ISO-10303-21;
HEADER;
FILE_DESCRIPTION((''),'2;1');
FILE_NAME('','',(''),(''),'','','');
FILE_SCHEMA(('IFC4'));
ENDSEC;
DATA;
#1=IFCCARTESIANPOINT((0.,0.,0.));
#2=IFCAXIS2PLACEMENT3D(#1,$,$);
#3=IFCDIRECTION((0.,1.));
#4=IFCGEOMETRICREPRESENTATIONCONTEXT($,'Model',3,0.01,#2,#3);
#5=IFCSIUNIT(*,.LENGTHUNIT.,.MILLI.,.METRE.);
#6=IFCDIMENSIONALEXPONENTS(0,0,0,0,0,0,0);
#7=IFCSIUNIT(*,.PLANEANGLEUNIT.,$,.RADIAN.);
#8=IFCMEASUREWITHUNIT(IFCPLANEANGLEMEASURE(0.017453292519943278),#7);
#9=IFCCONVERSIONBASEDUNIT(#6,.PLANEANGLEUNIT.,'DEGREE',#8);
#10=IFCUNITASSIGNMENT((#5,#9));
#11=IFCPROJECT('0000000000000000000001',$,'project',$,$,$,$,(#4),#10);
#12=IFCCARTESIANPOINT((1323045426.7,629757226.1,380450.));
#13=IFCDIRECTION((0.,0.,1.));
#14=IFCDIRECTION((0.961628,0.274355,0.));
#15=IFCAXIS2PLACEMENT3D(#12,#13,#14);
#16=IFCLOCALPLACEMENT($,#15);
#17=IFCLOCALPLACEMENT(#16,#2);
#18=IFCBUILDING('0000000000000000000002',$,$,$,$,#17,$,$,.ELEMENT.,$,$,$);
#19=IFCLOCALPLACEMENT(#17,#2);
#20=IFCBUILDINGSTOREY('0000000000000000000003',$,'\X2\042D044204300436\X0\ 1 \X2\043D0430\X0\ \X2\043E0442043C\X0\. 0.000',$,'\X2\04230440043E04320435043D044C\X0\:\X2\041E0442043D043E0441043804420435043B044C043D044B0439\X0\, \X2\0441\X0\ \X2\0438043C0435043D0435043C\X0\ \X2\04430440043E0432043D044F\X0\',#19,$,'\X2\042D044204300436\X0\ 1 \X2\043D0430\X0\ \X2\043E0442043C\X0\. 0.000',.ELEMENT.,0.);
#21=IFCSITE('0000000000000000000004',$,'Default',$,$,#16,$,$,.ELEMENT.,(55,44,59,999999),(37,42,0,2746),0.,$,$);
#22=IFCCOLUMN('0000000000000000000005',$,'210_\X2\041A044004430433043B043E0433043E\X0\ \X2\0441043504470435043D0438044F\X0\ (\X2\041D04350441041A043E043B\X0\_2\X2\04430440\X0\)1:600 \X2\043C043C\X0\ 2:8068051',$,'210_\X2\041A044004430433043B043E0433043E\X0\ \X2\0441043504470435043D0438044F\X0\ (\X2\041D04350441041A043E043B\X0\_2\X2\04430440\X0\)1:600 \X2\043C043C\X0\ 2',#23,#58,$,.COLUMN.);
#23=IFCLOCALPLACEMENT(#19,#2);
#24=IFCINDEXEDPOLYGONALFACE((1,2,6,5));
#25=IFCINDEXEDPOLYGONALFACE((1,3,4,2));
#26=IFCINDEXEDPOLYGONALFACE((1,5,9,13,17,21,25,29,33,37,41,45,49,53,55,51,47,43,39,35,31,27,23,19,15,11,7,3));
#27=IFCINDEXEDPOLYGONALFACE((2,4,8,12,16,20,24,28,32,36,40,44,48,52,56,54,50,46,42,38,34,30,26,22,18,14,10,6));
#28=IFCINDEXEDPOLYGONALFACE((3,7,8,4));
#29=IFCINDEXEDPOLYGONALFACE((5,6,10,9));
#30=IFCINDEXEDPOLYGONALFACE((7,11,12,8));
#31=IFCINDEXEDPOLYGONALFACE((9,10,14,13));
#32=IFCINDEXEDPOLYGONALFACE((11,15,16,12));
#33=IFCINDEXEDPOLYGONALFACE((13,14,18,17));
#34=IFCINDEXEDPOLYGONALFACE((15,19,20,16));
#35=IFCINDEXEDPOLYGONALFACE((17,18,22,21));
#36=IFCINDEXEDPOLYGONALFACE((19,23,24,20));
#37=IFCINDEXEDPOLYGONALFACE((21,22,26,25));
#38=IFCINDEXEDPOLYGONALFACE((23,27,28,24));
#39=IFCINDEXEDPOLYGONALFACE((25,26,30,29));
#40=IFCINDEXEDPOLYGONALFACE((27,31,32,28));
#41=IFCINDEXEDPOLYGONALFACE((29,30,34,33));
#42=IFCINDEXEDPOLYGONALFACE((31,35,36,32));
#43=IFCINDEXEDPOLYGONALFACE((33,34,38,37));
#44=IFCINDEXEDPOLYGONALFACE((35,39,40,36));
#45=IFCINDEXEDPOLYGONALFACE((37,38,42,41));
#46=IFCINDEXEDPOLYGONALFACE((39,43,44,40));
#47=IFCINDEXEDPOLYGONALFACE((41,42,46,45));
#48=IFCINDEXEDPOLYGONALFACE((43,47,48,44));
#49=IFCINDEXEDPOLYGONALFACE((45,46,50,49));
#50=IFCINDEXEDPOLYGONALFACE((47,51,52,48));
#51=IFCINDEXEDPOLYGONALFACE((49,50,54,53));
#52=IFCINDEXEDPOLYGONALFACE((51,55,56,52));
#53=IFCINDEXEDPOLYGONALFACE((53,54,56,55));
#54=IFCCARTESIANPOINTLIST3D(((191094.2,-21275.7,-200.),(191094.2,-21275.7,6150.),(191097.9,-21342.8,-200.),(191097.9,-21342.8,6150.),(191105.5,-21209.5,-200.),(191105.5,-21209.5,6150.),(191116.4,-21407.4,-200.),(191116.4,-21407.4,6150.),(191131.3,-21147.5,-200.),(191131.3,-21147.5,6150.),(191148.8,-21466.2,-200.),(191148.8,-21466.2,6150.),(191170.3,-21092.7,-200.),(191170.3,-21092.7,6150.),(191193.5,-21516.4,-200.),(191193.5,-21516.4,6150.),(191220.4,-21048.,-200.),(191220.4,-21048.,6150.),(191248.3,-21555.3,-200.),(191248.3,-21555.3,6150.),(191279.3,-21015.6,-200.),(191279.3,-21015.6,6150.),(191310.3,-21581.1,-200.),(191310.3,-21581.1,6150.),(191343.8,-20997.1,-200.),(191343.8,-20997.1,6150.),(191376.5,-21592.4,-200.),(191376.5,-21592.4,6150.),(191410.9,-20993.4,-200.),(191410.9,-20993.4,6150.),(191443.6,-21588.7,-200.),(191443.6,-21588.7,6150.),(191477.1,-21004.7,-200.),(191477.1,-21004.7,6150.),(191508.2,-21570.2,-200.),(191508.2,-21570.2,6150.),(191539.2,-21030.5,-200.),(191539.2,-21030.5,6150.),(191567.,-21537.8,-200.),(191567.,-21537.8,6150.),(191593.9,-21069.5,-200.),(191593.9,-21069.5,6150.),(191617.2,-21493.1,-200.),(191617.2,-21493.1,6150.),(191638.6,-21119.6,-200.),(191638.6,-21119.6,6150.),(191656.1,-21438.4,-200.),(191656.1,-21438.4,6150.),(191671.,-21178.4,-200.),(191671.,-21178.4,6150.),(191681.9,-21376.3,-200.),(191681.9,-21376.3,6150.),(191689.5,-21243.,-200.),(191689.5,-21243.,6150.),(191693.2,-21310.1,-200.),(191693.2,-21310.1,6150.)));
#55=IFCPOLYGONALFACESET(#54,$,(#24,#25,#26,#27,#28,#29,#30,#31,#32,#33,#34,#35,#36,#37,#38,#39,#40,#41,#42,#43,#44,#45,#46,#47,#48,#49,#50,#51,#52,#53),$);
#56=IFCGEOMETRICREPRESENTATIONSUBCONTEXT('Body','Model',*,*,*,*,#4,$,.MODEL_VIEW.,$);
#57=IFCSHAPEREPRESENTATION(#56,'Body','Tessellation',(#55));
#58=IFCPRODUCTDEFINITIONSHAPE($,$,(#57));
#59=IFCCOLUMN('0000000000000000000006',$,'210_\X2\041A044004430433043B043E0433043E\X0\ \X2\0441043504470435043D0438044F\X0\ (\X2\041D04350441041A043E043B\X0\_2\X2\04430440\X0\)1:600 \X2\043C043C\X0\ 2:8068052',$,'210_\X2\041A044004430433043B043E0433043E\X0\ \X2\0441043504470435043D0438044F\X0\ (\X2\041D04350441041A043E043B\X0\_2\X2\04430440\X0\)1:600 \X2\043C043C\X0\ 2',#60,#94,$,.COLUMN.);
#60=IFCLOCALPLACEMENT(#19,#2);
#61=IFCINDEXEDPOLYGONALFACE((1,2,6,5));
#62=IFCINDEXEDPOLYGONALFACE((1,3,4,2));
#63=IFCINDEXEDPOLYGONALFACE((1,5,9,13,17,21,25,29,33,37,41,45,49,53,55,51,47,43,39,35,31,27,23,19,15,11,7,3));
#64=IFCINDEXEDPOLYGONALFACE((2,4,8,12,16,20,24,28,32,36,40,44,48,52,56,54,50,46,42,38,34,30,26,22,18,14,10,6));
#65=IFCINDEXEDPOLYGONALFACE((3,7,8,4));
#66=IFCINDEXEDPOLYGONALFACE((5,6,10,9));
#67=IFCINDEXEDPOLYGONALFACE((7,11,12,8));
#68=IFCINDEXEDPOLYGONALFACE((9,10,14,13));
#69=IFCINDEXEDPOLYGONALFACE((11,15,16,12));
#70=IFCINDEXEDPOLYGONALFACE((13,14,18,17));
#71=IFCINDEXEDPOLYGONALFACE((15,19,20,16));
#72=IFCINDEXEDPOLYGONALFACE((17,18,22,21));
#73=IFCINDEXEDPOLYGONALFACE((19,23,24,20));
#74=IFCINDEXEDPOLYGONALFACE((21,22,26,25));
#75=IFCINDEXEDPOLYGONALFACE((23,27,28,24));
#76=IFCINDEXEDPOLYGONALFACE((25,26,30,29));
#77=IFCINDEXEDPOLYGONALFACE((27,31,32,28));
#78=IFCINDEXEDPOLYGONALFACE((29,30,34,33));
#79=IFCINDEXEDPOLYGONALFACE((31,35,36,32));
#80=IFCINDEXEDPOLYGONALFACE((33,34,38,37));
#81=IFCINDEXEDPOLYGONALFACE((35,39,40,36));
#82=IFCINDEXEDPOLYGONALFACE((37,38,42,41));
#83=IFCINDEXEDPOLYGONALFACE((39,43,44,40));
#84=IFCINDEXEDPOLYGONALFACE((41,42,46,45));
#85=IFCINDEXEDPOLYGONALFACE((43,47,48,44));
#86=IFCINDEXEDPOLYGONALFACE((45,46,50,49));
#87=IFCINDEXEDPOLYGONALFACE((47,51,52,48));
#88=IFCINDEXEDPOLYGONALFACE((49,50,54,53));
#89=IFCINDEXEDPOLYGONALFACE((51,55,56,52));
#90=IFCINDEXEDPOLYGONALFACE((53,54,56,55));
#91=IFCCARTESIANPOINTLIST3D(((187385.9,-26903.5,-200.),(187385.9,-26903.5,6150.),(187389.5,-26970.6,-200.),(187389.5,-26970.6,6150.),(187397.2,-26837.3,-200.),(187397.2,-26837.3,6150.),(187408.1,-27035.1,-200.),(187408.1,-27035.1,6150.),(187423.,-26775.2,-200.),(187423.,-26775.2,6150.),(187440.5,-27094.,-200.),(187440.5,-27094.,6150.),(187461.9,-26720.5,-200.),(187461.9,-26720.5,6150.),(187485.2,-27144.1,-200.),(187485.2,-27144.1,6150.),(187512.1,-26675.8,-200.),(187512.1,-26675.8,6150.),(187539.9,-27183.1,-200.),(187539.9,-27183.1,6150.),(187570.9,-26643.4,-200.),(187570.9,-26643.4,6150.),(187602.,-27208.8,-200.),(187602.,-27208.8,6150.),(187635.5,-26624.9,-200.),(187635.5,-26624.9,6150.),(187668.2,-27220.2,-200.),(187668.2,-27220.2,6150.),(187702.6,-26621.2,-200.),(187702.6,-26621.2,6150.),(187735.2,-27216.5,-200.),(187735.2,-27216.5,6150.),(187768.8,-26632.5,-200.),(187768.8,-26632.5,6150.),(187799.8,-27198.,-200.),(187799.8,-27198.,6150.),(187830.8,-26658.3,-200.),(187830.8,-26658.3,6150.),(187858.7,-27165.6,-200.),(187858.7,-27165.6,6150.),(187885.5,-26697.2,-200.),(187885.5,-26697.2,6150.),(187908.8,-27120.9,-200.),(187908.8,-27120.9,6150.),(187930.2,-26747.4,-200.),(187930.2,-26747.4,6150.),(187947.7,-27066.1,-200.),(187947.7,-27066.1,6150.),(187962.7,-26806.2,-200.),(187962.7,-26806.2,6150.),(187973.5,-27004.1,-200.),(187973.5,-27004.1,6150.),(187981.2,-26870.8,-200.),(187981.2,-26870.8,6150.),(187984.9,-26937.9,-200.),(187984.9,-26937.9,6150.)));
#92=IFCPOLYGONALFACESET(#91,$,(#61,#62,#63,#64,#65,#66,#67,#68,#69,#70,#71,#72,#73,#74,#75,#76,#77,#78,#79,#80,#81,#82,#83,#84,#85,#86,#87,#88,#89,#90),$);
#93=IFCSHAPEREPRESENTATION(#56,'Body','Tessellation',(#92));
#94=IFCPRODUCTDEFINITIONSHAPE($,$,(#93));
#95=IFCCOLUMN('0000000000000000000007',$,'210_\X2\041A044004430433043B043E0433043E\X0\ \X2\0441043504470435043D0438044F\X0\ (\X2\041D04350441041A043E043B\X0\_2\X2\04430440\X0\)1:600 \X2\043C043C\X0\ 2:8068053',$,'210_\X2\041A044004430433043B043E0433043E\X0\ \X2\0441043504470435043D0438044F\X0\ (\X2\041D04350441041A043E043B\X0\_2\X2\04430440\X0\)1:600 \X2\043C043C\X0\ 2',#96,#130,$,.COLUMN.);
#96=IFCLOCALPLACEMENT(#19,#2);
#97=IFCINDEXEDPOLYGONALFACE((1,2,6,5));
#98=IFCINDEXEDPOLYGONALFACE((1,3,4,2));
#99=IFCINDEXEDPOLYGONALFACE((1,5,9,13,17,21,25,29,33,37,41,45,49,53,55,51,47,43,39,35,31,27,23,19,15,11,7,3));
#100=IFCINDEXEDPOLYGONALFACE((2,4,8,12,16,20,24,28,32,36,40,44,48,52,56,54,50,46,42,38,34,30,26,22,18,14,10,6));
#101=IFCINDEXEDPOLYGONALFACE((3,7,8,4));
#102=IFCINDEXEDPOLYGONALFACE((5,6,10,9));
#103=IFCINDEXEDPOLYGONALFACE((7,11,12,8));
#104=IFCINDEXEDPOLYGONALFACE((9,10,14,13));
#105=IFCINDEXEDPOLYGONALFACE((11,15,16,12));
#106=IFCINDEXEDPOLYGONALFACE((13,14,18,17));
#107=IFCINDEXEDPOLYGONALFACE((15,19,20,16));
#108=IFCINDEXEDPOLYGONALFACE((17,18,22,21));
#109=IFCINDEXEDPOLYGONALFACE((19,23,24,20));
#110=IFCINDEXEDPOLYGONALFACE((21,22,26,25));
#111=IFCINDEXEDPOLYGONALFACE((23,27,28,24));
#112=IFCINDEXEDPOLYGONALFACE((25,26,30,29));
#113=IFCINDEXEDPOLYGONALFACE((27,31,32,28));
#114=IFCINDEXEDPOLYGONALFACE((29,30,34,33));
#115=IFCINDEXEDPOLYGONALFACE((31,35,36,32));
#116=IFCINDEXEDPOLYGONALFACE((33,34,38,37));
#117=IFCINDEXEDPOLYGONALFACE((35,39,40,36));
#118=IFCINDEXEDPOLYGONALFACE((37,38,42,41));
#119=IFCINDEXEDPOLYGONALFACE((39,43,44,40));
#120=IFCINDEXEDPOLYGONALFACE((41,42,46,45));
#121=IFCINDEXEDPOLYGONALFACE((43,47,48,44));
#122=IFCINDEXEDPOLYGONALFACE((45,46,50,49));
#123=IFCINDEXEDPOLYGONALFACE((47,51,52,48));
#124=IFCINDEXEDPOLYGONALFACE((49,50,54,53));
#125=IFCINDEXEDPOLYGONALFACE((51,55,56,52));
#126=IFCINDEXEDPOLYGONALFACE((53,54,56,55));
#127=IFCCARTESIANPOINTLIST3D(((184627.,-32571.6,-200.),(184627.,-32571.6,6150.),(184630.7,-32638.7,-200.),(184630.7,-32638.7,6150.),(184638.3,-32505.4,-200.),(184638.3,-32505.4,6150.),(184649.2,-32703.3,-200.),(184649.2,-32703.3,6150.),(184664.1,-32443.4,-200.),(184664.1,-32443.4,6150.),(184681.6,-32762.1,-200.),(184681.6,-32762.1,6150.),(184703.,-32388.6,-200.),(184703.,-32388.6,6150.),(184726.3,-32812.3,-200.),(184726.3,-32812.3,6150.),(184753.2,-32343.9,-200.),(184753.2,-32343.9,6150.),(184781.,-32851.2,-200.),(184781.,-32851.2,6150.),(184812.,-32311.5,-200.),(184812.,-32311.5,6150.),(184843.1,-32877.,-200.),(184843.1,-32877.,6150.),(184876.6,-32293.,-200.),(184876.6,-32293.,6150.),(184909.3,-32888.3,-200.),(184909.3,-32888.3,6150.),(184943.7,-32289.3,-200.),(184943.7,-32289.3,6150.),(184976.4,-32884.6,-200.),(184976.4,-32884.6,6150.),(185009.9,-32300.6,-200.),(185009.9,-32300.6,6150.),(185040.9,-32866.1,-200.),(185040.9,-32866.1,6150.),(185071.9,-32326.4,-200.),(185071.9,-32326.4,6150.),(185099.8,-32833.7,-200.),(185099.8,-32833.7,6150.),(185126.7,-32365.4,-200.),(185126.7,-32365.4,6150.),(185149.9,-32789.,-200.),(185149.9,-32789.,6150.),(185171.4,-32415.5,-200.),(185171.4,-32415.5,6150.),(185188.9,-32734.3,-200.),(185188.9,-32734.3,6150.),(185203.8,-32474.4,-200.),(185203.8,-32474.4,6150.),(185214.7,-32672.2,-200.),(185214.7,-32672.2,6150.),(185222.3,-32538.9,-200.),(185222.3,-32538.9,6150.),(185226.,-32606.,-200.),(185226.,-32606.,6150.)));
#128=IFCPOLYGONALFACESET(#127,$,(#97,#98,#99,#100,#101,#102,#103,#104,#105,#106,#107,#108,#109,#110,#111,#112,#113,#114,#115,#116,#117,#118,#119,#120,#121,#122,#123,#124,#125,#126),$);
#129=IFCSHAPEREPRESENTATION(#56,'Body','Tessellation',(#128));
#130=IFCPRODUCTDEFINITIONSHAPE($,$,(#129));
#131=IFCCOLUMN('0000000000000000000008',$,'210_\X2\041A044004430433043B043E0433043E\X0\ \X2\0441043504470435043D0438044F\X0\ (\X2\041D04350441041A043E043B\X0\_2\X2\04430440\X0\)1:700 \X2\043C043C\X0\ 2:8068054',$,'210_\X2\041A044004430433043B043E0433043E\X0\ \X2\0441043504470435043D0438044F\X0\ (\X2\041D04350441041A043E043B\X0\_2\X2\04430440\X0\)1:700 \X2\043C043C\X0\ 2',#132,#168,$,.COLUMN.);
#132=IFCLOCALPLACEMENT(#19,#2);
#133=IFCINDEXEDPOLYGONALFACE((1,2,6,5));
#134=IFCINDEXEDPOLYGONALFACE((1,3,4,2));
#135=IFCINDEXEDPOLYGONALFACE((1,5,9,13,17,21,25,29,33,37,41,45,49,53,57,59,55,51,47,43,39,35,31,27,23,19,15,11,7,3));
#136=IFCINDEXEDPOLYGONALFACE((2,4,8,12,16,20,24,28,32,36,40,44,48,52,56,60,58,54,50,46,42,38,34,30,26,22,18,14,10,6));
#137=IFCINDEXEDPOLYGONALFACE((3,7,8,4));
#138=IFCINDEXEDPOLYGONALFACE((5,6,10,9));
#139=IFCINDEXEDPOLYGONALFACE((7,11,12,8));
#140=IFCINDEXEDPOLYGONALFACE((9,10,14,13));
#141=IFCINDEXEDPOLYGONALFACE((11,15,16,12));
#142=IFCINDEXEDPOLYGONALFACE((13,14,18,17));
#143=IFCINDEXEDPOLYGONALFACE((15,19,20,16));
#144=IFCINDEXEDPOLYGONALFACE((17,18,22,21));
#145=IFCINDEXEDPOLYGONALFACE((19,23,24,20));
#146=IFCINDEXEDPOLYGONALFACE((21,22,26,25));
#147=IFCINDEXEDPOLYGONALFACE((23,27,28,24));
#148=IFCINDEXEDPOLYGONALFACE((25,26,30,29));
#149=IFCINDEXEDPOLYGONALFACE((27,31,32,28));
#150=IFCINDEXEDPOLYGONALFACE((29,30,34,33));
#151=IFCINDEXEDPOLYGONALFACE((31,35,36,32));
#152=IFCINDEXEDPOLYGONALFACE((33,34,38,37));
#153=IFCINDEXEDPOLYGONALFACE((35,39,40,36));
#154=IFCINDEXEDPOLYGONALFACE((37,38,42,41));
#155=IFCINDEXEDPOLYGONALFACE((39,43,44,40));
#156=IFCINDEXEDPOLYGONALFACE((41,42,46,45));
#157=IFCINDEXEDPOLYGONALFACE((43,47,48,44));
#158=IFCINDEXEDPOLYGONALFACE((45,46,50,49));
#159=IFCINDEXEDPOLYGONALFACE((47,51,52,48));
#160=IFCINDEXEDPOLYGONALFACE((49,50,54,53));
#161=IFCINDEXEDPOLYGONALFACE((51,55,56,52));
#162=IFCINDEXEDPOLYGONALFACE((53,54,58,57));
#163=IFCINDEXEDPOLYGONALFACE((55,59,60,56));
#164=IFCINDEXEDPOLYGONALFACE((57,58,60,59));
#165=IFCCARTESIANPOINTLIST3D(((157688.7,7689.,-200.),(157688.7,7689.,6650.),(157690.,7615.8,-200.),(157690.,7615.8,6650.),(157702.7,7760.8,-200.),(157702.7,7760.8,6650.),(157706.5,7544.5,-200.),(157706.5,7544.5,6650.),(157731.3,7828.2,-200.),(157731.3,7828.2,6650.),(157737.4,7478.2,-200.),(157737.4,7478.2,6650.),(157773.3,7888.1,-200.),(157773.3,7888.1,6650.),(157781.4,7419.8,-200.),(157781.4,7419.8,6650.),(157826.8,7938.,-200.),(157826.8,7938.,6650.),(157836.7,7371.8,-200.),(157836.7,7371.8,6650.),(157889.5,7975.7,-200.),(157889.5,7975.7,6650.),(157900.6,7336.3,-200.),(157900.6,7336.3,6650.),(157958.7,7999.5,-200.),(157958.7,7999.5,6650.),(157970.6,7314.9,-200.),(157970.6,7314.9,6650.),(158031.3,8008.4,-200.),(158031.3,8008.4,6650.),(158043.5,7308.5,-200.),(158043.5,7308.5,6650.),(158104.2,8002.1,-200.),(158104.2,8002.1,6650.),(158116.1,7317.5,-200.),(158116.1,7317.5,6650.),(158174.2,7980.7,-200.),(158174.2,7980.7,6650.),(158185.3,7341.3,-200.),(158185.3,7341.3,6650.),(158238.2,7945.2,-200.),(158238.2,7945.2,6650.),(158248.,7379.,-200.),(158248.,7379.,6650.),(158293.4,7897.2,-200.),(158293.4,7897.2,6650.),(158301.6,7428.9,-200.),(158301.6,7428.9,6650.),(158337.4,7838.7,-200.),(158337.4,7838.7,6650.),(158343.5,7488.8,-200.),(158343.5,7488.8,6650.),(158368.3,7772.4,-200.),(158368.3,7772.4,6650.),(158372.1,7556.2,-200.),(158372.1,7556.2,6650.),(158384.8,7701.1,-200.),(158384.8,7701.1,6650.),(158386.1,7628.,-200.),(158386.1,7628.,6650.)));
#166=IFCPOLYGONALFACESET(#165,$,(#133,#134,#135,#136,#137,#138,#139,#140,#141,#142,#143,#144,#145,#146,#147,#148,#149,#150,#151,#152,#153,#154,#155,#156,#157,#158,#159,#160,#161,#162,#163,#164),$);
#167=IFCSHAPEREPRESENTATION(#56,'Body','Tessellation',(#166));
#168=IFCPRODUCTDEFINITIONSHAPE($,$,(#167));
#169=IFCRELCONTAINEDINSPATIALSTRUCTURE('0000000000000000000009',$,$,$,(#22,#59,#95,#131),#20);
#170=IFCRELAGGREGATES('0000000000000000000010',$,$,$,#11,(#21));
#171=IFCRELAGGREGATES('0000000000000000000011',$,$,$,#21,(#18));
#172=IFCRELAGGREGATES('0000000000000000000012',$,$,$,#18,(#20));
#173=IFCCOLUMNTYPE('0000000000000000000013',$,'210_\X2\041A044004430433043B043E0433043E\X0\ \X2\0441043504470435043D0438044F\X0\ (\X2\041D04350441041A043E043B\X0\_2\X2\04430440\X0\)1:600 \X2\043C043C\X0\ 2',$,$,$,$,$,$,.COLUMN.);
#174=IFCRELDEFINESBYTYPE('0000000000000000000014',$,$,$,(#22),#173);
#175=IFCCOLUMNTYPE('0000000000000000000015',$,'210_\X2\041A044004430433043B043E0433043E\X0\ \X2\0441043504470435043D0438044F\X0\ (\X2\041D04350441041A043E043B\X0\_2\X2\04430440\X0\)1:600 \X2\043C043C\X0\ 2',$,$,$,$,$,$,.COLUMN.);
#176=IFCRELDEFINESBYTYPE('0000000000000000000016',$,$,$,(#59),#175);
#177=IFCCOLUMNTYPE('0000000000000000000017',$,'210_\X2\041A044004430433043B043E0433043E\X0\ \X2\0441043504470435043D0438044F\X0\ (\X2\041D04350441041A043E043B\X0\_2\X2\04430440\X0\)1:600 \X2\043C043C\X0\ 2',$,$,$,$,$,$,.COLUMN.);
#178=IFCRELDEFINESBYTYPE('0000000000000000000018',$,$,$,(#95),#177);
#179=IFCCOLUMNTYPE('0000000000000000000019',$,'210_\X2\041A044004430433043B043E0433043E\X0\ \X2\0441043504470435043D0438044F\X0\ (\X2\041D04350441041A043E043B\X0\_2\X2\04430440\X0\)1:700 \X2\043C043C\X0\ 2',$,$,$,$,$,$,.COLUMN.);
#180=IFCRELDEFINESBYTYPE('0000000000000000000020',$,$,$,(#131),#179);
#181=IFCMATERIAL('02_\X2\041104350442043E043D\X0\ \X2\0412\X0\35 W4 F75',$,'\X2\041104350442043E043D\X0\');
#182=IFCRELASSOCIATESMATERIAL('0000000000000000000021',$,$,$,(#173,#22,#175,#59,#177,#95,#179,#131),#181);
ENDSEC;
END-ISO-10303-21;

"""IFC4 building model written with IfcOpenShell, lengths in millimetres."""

from ifc_helpers import new_model, entity, si_unit, converted_unit, direction, frame, origin, place, context, subcontext, project, spatial, arc, indexed_curve, outline, extrude, source, transform, mapped, material, type_object, type_shapes, element, save


model = new_model("IFC4")

# Units and contexts
model_context = context("Model", 3, precision=0.01, world=origin(), true_north=direction((0.0, 1.0)))
body_context = subcontext(model_context, "Body", "Model", "MODEL_VIEW")
ifc_project = project(units=[si_unit("LENGTHUNIT", "METRE", prefix="MILLI"), converted_unit("PLANEANGLEUNIT", "DEGREE", entity("IfcPlaneAngleMeasure", 0.017453292519943278), si_unit("PLANEANGLEUNIT", "RADIAN"), dimensions=[0, 0, 0, 0, 0, 0, 0])], contexts=[model_context])

# Site, building, storey
site_placement = place(None, frame((1323045426.7, 629757226.1, 380450.0), z_axis=(0.0, 0.0, 1.0), x_axis=(0.961628, 0.274355, 0.0)))
site = spatial("IfcSite", under=ifc_project, at=site_placement, Name="Default", CompositionType="ELEMENT", RefLatitude=(55, 44, 59, 999999), RefLongitude=(37, 42, 0, 2746), RefElevation=0.0)
building_placement = place(site_placement, origin())
building = spatial("IfcBuilding", under=site, at=building_placement, CompositionType="ELEMENT")
storey_placement = place(building_placement, origin())
storey = spatial("IfcBuildingStorey", under=building, at=storey_placement, Name="Этаж 1 на отм. 0.000", ObjectType="Уровень:Относительный, с именем уровня", LongName="Этаж 1 на отм. 0.000", CompositionType="ELEMENT", Elevation=0.0)

# Columns
ifc_material = material(Name="02_Бетон В35 W4 F75", Category="Бетон")
column_type_1 = type_object("IfcColumnType", Name="210_Круглого сечения (НесКол_2ур)1:600 мм 2", PredefinedType="COLUMN", material=ifc_material)
shared_shape_1 = source(origin(), body_context, "Body", "SweptSolid", [
    extrude(outline(indexed_curve([(-300.0, 0.0), (0.0, -300.0), (300.0, 0.0), (0.0, 300.0)], segments=[arc(1, 2, 3), arc(3, 4, 1)], self_intersect=False)), frame((191393.7, -21292.9, -200.0), z_axis=(0.0, 0.0, 1.0), x_axis=(0.87462, -0.48481, 0.0)), (0.0, 0.0, 1.0), 6350.0),
])
type_shapes(column_type_1, [shared_shape_1])
column_1_placement = place(storey_placement, origin())
element("IfcColumn", 1, at=column_1_placement, inside=storey, type_object=column_type_1, material=ifc_material, Name="210_Круглого сечения (НесКол_2ур)1:600 мм 2:8068051", ObjectType="210_Круглого сечения (НесКол_2ур)1:600 мм 2", PredefinedType="COLUMN", context=body_context, shape_type="MappedRepresentation", body=[
    mapped(shared_shape_1, transform((0.0, 0.0, 0.0), scale=1.0)),
])
column_type_2 = type_object("IfcColumnType", Name="210_Круглого сечения (НесКол_2ур)1:600 мм 2", PredefinedType="COLUMN", material=ifc_material)
shared_shape_2 = source(origin(), body_context, "Body", "SweptSolid", [
    extrude(outline(indexed_curve([(-300.0, 0.0), (0.0, -300.0), (300.0, 0.0), (0.0, 300.0)], segments=[arc(1, 2, 3), arc(3, 4, 1)], self_intersect=False)), frame((187685.4, -26920.7, -200.0), z_axis=(0.0, 0.0, 1.0), x_axis=(0.87462, -0.48481, 0.0)), (0.0, 0.0, 1.0), 6350.0),
])
type_shapes(column_type_2, [shared_shape_2])
column_2_placement = place(storey_placement, origin())
element("IfcColumn", 2, at=column_2_placement, inside=storey, type_object=column_type_2, material=ifc_material, Name="210_Круглого сечения (НесКол_2ур)1:600 мм 2:8068052", ObjectType="210_Круглого сечения (НесКол_2ур)1:600 мм 2", PredefinedType="COLUMN", context=body_context, shape_type="MappedRepresentation", body=[
    mapped(shared_shape_2, transform((0.0, 0.0, 0.0), scale=1.0)),
])
column_type_3 = type_object("IfcColumnType", Name="210_Круглого сечения (НесКол_2ур)1:600 мм 2", PredefinedType="COLUMN", material=ifc_material)
shared_shape_3 = source(origin(), body_context, "Body", "SweptSolid", [
    extrude(outline(indexed_curve([(-300.0, 0.0), (0.0, -300.0), (300.0, 0.0), (0.0, 300.0)], segments=[arc(1, 2, 3), arc(3, 4, 1)], self_intersect=False)), frame((184926.5, -32588.8, -200.0), z_axis=(0.0, 0.0, 1.0), x_axis=(0.87462, -0.48481, 0.0)), (0.0, 0.0, 1.0), 6350.0),
])
type_shapes(column_type_3, [shared_shape_3])
column_3_placement = place(storey_placement, origin())
element("IfcColumn", 3, at=column_3_placement, inside=storey, type_object=column_type_3, material=ifc_material, Name="210_Круглого сечения (НесКол_2ур)1:600 мм 2:8068053", ObjectType="210_Круглого сечения (НесКол_2ур)1:600 мм 2", PredefinedType="COLUMN", context=body_context, shape_type="MappedRepresentation", body=[
    mapped(shared_shape_3, transform((0.0, 0.0, 0.0), scale=1.0)),
])
column_type_4 = type_object("IfcColumnType", Name="210_Круглого сечения (НесКол_2ур)1:700 мм 2", PredefinedType="COLUMN", material=ifc_material)
shared_shape_4 = source(origin(), body_context, "Body", "SweptSolid", [
    extrude(outline(indexed_curve([(-350.0, 0.0), (0.0, -350.0), (350.0, 0.0), (0.0, 350.0)], segments=[arc(1, 2, 3), arc(3, 4, 1)], self_intersect=False)), frame((158037.4, 7658.5, -200.0), z_axis=(0.0, 0.0, 1.0), x_axis=(0.87462, -0.48481, 0.0)), (0.0, 0.0, 1.0), 6850.0),
])
type_shapes(column_type_4, [shared_shape_4])
column_4_placement = place(storey_placement, origin())
element("IfcColumn", 4, at=column_4_placement, inside=storey, type_object=column_type_4, material=ifc_material, Name="210_Круглого сечения (НесКол_2ур)1:700 мм 2:8068054", ObjectType="210_Круглого сечения (НесКол_2ур)1:700 мм 2", PredefinedType="COLUMN", context=body_context, shape_type="MappedRepresentation", body=[
    mapped(shared_shape_4, transform((0.0, 0.0, 0.0), scale=1.0)),
])

save(model, "model.ifc")
